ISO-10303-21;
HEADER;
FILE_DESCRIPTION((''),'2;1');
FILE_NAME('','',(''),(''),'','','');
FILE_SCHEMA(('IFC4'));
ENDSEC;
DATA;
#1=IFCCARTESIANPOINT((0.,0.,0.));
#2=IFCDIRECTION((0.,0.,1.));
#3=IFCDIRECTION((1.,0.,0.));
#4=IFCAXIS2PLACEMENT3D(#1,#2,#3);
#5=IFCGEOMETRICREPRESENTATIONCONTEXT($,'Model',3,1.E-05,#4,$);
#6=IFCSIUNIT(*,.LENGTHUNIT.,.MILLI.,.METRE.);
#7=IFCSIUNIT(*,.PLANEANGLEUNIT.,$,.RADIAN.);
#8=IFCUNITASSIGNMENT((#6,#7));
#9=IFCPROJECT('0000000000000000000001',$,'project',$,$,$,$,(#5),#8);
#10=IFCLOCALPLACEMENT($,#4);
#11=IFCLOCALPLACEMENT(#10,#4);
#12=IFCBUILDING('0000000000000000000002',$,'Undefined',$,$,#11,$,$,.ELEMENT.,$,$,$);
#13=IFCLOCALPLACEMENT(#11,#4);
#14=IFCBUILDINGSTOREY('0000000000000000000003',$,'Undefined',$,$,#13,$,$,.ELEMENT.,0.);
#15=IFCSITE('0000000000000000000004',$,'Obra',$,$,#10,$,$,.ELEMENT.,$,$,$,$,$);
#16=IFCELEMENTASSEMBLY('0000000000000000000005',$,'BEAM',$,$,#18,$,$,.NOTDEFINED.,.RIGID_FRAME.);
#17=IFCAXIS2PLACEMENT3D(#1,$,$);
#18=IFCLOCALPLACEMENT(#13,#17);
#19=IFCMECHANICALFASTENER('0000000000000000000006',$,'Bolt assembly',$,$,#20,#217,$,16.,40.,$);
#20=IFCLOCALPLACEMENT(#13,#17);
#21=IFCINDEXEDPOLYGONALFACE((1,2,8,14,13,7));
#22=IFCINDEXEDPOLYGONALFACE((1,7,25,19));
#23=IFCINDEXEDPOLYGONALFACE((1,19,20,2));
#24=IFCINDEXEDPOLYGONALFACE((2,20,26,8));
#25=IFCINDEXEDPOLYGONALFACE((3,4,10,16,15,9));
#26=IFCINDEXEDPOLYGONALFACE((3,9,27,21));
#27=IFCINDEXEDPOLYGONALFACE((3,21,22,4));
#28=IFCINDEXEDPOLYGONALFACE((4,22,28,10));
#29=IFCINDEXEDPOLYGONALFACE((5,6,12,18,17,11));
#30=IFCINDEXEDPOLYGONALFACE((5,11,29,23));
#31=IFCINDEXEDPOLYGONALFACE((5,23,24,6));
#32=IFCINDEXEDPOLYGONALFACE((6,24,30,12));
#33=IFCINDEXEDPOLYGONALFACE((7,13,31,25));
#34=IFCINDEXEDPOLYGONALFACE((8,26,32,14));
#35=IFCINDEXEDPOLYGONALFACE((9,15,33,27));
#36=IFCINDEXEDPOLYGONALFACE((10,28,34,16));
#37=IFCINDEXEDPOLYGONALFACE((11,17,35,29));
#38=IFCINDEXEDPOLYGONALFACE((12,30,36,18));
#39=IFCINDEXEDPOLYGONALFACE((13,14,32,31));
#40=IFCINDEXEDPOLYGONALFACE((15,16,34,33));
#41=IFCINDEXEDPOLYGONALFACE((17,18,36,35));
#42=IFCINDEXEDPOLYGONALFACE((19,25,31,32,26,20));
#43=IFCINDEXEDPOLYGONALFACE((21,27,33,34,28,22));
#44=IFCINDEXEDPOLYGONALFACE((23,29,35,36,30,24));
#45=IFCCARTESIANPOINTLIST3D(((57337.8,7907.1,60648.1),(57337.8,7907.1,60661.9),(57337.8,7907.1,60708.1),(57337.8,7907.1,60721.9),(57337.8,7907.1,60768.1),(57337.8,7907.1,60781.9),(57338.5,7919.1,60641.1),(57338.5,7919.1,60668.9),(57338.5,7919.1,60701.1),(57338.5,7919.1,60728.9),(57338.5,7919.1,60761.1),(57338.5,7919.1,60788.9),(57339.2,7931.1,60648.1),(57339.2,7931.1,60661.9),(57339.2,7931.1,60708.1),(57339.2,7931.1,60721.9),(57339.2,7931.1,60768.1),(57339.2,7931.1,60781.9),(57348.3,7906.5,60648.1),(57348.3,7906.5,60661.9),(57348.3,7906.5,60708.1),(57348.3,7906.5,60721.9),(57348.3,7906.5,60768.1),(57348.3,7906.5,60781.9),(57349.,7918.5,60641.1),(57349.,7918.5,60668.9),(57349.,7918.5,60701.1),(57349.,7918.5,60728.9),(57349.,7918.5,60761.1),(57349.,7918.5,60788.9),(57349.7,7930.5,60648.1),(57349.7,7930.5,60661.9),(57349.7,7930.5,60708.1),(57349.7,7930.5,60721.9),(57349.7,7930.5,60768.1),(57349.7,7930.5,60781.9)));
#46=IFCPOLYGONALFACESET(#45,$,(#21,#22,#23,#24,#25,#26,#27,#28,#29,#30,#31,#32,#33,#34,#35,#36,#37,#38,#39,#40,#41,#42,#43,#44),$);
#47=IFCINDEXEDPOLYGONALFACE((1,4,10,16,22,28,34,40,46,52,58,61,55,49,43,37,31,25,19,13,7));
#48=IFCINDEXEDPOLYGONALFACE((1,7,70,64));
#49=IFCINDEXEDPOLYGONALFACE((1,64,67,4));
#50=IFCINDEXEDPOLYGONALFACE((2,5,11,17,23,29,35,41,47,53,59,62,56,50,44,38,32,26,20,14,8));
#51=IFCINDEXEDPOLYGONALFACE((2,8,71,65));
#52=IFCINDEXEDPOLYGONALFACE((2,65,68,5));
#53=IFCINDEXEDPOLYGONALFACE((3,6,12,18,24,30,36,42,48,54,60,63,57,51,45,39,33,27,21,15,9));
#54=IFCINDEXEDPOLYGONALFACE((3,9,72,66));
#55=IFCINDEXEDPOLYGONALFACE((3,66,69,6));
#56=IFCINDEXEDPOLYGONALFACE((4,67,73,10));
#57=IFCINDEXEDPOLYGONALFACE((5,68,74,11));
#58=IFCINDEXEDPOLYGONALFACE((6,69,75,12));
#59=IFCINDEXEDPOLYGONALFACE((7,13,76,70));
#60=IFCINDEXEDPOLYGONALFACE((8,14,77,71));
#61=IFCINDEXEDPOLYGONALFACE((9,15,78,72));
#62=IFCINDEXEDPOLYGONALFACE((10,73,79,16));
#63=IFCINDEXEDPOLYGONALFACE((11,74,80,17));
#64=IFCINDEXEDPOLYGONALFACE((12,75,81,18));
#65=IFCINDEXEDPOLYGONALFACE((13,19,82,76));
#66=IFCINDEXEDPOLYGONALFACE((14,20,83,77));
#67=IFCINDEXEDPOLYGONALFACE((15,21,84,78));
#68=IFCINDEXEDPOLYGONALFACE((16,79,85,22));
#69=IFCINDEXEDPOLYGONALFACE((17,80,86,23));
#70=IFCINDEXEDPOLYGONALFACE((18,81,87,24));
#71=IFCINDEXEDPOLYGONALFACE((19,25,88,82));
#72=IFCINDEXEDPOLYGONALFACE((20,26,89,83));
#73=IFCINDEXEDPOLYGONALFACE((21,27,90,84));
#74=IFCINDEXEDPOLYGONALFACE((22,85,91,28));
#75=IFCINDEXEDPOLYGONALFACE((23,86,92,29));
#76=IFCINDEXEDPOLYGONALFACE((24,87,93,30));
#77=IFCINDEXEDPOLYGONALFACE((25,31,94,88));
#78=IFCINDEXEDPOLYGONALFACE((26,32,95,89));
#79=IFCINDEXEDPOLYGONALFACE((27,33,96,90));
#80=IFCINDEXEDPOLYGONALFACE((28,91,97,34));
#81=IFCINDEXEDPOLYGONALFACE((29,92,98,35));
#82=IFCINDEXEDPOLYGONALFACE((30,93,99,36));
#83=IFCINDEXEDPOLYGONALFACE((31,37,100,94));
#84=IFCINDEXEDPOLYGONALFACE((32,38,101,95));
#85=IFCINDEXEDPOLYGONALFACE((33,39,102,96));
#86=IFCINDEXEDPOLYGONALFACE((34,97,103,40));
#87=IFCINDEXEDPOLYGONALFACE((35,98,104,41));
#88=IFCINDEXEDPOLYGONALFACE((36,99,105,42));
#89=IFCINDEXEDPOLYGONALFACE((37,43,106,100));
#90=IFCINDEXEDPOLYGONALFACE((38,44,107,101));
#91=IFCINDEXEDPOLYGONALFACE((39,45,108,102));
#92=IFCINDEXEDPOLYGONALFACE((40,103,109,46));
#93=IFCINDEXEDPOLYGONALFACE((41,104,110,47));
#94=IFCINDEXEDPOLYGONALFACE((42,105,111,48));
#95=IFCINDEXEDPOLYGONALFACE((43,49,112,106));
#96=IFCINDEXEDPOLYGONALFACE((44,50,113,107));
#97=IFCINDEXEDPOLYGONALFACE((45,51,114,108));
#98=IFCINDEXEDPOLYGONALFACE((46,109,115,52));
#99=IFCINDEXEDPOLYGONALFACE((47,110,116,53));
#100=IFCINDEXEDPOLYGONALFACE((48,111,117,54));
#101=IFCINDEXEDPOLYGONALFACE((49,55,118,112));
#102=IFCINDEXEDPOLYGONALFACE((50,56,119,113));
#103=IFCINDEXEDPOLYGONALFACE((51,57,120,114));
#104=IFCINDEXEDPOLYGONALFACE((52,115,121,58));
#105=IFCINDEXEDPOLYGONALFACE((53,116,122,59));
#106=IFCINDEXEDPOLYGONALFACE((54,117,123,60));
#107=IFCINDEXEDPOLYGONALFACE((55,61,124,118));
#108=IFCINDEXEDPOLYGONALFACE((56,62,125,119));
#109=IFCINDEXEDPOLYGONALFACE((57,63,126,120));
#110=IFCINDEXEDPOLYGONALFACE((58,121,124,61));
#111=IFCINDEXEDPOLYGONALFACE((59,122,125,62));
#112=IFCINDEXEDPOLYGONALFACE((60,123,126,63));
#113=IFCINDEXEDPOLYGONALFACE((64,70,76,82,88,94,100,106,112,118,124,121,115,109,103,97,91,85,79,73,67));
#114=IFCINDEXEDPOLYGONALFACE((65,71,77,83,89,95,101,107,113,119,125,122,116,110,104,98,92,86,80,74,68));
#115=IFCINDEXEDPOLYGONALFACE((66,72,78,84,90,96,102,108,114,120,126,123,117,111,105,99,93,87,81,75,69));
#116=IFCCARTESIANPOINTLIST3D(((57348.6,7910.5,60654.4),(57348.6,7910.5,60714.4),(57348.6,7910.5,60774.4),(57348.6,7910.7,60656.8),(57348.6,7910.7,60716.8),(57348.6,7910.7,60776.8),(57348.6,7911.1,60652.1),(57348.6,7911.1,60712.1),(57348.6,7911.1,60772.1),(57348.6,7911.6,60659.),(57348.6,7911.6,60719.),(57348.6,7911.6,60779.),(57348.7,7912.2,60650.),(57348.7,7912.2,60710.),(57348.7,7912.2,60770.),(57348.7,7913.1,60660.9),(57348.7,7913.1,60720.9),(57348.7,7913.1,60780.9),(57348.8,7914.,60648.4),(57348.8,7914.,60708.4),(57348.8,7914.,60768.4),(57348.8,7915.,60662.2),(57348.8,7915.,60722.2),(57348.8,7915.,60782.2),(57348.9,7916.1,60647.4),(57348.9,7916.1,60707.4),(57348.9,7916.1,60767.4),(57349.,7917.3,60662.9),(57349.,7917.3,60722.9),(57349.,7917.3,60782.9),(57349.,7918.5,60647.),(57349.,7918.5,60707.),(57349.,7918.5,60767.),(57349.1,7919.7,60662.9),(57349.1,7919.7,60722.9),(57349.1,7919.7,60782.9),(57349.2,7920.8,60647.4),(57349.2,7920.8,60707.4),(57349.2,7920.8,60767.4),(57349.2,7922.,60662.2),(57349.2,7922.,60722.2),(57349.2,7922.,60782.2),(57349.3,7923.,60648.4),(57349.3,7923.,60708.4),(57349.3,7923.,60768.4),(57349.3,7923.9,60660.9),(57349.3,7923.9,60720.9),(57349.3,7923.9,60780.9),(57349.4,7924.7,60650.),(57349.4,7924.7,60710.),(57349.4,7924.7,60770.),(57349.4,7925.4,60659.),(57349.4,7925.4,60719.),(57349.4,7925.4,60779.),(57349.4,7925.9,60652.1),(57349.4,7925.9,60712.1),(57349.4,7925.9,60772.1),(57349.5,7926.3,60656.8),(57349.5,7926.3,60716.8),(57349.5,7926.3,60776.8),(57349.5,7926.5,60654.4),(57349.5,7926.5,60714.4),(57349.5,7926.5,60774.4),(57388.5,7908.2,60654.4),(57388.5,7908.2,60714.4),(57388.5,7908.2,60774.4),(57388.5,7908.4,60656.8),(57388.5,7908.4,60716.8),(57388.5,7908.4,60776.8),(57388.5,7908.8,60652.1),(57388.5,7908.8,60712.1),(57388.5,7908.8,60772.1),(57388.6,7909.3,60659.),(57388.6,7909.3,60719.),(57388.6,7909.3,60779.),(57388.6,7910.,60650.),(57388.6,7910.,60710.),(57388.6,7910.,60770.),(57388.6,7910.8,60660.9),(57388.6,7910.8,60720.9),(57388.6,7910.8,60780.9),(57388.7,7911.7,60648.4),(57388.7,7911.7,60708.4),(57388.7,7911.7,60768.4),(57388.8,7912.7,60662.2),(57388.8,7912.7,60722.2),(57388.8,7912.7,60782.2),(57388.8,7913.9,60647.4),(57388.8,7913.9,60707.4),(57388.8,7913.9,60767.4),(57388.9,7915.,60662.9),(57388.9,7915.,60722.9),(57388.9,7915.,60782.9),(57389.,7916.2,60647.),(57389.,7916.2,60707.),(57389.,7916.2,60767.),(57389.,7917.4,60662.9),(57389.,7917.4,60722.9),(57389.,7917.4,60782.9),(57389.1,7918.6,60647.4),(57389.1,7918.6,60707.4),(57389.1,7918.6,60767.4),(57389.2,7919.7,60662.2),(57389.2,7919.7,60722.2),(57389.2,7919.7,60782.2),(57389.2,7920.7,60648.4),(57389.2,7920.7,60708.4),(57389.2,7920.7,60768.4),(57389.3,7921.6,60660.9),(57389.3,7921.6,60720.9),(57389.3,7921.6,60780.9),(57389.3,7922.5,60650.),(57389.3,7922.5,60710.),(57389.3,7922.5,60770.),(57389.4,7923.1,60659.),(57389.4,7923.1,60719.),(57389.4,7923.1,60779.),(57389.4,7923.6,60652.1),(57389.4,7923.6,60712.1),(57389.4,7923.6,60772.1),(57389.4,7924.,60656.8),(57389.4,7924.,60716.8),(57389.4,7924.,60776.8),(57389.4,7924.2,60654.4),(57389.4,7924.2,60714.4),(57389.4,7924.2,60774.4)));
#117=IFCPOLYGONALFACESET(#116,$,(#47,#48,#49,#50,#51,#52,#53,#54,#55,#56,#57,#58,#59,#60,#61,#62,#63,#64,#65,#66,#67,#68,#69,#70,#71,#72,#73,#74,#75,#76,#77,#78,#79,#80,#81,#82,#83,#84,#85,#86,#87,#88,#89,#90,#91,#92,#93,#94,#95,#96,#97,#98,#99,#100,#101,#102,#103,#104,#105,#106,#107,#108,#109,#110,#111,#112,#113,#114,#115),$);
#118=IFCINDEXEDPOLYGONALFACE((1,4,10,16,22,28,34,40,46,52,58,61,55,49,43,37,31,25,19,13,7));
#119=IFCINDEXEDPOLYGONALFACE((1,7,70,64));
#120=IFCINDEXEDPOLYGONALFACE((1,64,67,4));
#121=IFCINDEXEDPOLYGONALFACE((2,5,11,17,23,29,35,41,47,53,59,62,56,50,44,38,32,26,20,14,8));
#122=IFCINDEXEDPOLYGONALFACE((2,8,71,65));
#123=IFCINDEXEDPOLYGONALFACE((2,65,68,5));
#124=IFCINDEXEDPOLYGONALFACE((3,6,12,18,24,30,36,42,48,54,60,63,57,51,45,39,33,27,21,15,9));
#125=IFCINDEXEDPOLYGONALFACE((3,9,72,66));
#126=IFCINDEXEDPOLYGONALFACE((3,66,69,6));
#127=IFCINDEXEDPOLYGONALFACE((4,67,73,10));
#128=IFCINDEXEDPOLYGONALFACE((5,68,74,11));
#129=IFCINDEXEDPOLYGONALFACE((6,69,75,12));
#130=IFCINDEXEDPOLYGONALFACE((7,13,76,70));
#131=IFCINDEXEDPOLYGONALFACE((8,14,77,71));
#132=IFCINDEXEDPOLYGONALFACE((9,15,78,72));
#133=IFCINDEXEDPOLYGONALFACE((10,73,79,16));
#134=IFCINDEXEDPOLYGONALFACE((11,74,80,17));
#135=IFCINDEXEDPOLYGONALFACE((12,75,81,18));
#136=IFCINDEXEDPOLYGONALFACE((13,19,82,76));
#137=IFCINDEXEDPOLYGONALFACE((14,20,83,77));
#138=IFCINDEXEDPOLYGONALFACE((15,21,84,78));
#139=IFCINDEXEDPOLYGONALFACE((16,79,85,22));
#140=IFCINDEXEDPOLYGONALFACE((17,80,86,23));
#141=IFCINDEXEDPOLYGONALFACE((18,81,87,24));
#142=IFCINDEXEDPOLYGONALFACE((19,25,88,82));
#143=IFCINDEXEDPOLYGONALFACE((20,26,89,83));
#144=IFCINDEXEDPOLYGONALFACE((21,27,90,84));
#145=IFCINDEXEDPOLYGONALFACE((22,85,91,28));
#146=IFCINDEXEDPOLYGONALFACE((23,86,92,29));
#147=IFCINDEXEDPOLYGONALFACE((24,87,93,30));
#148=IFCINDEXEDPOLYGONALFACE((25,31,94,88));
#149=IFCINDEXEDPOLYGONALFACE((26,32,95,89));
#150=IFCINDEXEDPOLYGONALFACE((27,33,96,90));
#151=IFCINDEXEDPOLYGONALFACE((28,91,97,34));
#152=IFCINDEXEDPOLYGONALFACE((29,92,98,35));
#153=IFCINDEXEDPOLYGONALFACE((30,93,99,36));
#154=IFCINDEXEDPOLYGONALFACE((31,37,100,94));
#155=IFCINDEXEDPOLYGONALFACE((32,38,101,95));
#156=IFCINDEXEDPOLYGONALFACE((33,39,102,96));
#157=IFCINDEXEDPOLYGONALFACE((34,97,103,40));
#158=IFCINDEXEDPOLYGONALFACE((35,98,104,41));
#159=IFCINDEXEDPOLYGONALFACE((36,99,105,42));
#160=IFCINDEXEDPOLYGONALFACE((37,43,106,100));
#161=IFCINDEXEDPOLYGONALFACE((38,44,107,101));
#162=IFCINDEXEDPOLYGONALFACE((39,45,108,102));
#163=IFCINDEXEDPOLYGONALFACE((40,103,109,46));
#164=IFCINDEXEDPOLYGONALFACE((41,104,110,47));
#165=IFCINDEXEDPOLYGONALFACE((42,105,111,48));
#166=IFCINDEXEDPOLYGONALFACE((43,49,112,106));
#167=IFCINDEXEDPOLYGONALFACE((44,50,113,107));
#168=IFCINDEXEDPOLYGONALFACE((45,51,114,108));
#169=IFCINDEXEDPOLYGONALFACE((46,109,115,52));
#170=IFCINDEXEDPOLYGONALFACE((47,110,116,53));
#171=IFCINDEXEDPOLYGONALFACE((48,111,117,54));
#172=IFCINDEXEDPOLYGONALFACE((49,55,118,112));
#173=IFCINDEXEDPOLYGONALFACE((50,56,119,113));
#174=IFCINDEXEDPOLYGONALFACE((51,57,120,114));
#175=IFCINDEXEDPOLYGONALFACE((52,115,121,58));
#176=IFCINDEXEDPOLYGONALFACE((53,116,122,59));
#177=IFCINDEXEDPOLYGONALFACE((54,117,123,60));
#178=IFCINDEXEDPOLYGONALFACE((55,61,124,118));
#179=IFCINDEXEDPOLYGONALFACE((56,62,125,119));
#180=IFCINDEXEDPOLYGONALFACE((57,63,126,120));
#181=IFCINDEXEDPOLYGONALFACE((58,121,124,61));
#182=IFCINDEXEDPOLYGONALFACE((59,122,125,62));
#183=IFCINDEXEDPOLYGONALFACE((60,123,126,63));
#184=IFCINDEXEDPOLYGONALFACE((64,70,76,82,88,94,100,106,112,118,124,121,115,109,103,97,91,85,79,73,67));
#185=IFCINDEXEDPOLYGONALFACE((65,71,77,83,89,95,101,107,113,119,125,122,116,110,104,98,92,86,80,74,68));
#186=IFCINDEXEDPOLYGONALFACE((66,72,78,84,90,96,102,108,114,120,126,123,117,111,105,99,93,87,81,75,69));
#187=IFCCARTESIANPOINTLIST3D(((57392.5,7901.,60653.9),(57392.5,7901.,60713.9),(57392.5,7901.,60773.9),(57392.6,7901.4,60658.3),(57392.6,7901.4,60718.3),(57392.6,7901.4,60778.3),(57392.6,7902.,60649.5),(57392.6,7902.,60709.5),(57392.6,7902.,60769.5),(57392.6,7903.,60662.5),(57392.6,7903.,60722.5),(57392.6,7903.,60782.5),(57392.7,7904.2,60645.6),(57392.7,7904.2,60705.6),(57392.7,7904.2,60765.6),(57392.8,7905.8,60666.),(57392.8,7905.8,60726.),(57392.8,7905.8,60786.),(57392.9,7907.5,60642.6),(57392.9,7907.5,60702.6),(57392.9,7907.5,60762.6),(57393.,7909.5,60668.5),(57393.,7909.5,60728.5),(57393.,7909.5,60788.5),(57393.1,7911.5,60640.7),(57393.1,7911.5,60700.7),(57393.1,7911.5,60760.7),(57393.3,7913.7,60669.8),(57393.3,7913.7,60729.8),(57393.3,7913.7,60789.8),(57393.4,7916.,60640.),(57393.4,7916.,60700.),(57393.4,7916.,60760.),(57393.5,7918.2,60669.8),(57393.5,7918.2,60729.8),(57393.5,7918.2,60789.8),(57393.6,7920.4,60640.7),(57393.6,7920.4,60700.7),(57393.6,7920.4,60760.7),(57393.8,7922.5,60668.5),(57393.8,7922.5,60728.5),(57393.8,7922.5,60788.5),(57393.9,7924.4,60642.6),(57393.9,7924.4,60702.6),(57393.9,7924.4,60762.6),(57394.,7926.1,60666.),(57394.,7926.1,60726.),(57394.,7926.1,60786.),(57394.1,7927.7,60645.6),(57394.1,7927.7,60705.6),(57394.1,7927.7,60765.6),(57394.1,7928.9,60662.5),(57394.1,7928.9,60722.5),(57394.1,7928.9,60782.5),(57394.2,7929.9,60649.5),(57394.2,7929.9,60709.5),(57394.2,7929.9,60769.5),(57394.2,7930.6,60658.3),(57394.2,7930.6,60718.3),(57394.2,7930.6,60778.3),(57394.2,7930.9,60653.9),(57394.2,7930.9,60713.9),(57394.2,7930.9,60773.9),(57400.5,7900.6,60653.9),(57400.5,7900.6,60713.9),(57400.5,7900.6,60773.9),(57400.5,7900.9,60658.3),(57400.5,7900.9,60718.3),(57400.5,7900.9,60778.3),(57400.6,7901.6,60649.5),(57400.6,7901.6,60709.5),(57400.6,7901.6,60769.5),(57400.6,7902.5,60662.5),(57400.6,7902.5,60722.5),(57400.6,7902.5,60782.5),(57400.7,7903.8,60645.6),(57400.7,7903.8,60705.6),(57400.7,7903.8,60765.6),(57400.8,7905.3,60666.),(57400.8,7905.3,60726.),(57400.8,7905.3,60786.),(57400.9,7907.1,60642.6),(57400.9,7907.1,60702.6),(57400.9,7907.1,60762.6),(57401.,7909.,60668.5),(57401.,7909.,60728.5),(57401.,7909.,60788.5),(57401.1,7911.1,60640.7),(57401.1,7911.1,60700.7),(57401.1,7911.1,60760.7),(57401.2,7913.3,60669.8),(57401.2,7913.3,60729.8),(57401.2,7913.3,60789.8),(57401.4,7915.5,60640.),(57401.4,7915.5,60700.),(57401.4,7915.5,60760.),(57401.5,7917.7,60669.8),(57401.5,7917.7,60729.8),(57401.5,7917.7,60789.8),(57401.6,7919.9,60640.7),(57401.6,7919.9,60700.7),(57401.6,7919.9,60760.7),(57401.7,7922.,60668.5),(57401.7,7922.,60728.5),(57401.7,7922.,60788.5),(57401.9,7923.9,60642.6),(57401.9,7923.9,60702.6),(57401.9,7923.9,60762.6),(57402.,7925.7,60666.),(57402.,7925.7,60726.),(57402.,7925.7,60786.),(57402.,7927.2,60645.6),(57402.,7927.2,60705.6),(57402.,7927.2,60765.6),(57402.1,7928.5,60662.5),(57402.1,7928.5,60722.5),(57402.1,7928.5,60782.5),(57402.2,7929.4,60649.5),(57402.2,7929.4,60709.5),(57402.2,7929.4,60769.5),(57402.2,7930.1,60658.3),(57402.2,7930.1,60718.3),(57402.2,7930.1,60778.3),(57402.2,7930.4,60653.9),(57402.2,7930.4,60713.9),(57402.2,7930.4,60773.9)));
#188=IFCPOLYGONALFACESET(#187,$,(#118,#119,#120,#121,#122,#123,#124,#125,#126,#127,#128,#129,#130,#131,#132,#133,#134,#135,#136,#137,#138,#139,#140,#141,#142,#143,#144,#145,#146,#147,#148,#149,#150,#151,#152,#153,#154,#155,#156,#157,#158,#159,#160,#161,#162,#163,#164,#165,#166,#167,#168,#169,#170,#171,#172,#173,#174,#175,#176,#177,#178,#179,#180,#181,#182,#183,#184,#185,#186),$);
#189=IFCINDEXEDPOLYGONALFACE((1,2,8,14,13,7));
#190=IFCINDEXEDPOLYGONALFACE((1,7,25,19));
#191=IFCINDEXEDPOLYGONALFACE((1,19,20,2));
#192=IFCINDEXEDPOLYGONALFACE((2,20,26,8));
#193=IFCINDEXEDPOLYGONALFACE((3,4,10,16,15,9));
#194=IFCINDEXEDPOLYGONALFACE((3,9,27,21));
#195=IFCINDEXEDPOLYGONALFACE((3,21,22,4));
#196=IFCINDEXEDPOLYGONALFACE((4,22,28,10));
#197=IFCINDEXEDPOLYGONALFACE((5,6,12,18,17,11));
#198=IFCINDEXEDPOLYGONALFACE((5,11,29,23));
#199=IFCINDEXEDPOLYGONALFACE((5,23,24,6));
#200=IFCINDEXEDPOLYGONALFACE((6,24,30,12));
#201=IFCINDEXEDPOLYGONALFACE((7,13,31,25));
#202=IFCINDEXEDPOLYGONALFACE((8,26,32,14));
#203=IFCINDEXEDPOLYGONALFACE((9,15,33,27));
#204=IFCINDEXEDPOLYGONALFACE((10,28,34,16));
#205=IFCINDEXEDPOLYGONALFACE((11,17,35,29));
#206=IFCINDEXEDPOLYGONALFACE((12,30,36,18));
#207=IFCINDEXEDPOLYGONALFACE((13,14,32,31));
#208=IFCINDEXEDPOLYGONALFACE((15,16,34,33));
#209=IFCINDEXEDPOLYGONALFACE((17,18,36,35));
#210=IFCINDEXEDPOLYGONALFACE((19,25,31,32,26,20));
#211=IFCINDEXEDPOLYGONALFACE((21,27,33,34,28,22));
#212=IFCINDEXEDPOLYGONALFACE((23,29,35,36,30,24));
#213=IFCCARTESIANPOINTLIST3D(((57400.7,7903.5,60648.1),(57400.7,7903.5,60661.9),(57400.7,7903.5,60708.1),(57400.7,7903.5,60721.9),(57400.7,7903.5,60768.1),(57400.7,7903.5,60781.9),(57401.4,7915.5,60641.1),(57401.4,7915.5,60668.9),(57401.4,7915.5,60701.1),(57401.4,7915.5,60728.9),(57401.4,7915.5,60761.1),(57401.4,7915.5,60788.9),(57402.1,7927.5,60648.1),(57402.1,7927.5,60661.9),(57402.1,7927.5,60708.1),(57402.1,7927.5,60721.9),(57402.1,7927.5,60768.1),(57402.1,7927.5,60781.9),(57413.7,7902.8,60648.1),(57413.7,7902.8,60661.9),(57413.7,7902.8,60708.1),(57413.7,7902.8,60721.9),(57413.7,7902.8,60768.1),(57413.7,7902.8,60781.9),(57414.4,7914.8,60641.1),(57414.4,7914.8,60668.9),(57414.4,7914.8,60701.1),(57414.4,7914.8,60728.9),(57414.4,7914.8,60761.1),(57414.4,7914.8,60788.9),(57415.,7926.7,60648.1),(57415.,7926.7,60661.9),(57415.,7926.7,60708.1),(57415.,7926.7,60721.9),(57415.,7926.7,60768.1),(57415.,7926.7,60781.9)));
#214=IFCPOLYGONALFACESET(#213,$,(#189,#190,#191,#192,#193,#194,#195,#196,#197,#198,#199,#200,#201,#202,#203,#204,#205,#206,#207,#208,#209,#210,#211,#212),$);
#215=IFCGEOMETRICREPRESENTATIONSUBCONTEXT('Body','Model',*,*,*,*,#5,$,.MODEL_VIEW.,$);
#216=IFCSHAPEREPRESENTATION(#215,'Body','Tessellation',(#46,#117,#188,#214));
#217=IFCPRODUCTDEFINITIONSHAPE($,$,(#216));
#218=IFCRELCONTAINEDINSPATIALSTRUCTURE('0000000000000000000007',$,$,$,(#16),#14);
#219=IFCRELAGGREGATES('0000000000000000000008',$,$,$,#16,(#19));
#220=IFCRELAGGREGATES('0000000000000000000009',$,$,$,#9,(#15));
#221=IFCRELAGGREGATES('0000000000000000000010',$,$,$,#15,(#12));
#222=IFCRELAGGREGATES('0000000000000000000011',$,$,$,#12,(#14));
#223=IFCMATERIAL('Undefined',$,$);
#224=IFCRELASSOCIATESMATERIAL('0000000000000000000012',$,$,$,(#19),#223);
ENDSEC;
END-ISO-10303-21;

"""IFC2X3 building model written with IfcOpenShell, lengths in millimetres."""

from ifc_helpers import new_model, si_unit, frame, origin_with_axes, origin_2d_with_axis, place, context, subcontext, project, spatial, polyline, circle, outline, extrude, source, transform, mapped, material, element, aggregate, save


model = new_model("IFC2X3")

# Units and contexts
model_context = context("Model", 3, precision=1e-05, world=origin_with_axes())
body_context = subcontext(model_context, "Body", "Model", "MODEL_VIEW")
ifc_project = project(units=[si_unit("LENGTHUNIT", "METRE", prefix="MILLI"), si_unit("PLANEANGLEUNIT", "RADIAN")], contexts=[model_context])

# Site, building, storey
site_placement = place(None, origin_with_axes())
site = spatial("IfcSite", under=ifc_project, at=site_placement, Name="Obra", CompositionType="ELEMENT")
building_placement = place(site_placement, origin_with_axes())
building = spatial("IfcBuilding", under=site, at=building_placement, Name="Undefined", CompositionType="ELEMENT")
storey_placement = place(building_placement, origin_with_axes())
storey = spatial("IfcBuildingStorey", under=building, at=storey_placement, Name="Undefined", CompositionType="ELEMENT", Elevation=0.0)

# Element assembly, mechanical fastener
ifc_material_1 = material(Name="Undefined")
shared_shape_1 = source(origin_with_axes(), body_context, "Body", "SweptSolid", [
    extrude(outline(polyline([(13.9, 0.0), (6.9, 12.0), (-6.9, 12.0), (-13.9, 0.0), (-6.9, -12.0), (6.9, -12.0), (13.9, 0.0)])), frame((0.0, -19.7, 0.0), z_axis=(0.0, 1.0, 0.0), x_axis=(1.0, 0.0, 0.0)), (0.0, 0.0, 1.0), 10.6),
    extrude(circle(Radius=8.0, at=origin_2d_with_axis()), frame((0.0, -9.1, 0.0), z_axis=(0.0, 1.0, 0.0), x_axis=(1.0, 0.0, 0.0)), (0.0, 0.0, 1.0), 40.0),
    extrude(circle(Radius=15.0, at=origin_2d_with_axis()), frame((0.0, 35.3, 0.0), z_axis=(0.0, 1.0, 0.0), x_axis=(1.0, 0.0, 0.0)), (0.0, 0.0, 1.0), 8.0),
    extrude(outline(polyline([(13.9, 0.0), (6.9, 12.0), (-6.9, 12.0), (-13.9, 0.0), (-6.9, -12.0), (6.9, -12.0), (13.9, 0.0)])), frame((0.0, 43.3, 0.0), z_axis=(0.0, 1.0, 0.0), x_axis=(1.0, 0.0, 0.0)), (0.0, 0.0, 1.0), 13.0),
])
assembly_1_placement = place(storey_placement, origin_with_axes())
assembly_1 = element("IfcElementAssembly", 1, at=assembly_1_placement, inside=storey, Name="BEAM", AssemblyPlace="NOTDEFINED", PredefinedType="RIGID_FRAME")
mechanical_fastener_1_placement = place(assembly_1_placement, frame((57361.0, 7967.9, 60835.0), z_axis=(-0.05711, -0.998368, 0.0), x_axis=(0.0, 0.0, -1.0)))
mechanical_fastener_1 = element("IfcMechanicalFastener", 2, at=mechanical_fastener_1_placement, material=ifc_material_1, Name="Bolt assembly", NominalDiameter=16.0, NominalLength=40.0, context=body_context, shape_type="MappedRepresentation", body=[
    mapped(shared_shape_1, transform((60.0, 0.0, 50.0))),
    mapped(shared_shape_1, transform((120.0, 0.0, 50.0))),
    mapped(shared_shape_1, transform((180.0, 0.0, 50.0))),
])

aggregate(assembly_1, [mechanical_fastener_1])

save(model, "model.ifc")
